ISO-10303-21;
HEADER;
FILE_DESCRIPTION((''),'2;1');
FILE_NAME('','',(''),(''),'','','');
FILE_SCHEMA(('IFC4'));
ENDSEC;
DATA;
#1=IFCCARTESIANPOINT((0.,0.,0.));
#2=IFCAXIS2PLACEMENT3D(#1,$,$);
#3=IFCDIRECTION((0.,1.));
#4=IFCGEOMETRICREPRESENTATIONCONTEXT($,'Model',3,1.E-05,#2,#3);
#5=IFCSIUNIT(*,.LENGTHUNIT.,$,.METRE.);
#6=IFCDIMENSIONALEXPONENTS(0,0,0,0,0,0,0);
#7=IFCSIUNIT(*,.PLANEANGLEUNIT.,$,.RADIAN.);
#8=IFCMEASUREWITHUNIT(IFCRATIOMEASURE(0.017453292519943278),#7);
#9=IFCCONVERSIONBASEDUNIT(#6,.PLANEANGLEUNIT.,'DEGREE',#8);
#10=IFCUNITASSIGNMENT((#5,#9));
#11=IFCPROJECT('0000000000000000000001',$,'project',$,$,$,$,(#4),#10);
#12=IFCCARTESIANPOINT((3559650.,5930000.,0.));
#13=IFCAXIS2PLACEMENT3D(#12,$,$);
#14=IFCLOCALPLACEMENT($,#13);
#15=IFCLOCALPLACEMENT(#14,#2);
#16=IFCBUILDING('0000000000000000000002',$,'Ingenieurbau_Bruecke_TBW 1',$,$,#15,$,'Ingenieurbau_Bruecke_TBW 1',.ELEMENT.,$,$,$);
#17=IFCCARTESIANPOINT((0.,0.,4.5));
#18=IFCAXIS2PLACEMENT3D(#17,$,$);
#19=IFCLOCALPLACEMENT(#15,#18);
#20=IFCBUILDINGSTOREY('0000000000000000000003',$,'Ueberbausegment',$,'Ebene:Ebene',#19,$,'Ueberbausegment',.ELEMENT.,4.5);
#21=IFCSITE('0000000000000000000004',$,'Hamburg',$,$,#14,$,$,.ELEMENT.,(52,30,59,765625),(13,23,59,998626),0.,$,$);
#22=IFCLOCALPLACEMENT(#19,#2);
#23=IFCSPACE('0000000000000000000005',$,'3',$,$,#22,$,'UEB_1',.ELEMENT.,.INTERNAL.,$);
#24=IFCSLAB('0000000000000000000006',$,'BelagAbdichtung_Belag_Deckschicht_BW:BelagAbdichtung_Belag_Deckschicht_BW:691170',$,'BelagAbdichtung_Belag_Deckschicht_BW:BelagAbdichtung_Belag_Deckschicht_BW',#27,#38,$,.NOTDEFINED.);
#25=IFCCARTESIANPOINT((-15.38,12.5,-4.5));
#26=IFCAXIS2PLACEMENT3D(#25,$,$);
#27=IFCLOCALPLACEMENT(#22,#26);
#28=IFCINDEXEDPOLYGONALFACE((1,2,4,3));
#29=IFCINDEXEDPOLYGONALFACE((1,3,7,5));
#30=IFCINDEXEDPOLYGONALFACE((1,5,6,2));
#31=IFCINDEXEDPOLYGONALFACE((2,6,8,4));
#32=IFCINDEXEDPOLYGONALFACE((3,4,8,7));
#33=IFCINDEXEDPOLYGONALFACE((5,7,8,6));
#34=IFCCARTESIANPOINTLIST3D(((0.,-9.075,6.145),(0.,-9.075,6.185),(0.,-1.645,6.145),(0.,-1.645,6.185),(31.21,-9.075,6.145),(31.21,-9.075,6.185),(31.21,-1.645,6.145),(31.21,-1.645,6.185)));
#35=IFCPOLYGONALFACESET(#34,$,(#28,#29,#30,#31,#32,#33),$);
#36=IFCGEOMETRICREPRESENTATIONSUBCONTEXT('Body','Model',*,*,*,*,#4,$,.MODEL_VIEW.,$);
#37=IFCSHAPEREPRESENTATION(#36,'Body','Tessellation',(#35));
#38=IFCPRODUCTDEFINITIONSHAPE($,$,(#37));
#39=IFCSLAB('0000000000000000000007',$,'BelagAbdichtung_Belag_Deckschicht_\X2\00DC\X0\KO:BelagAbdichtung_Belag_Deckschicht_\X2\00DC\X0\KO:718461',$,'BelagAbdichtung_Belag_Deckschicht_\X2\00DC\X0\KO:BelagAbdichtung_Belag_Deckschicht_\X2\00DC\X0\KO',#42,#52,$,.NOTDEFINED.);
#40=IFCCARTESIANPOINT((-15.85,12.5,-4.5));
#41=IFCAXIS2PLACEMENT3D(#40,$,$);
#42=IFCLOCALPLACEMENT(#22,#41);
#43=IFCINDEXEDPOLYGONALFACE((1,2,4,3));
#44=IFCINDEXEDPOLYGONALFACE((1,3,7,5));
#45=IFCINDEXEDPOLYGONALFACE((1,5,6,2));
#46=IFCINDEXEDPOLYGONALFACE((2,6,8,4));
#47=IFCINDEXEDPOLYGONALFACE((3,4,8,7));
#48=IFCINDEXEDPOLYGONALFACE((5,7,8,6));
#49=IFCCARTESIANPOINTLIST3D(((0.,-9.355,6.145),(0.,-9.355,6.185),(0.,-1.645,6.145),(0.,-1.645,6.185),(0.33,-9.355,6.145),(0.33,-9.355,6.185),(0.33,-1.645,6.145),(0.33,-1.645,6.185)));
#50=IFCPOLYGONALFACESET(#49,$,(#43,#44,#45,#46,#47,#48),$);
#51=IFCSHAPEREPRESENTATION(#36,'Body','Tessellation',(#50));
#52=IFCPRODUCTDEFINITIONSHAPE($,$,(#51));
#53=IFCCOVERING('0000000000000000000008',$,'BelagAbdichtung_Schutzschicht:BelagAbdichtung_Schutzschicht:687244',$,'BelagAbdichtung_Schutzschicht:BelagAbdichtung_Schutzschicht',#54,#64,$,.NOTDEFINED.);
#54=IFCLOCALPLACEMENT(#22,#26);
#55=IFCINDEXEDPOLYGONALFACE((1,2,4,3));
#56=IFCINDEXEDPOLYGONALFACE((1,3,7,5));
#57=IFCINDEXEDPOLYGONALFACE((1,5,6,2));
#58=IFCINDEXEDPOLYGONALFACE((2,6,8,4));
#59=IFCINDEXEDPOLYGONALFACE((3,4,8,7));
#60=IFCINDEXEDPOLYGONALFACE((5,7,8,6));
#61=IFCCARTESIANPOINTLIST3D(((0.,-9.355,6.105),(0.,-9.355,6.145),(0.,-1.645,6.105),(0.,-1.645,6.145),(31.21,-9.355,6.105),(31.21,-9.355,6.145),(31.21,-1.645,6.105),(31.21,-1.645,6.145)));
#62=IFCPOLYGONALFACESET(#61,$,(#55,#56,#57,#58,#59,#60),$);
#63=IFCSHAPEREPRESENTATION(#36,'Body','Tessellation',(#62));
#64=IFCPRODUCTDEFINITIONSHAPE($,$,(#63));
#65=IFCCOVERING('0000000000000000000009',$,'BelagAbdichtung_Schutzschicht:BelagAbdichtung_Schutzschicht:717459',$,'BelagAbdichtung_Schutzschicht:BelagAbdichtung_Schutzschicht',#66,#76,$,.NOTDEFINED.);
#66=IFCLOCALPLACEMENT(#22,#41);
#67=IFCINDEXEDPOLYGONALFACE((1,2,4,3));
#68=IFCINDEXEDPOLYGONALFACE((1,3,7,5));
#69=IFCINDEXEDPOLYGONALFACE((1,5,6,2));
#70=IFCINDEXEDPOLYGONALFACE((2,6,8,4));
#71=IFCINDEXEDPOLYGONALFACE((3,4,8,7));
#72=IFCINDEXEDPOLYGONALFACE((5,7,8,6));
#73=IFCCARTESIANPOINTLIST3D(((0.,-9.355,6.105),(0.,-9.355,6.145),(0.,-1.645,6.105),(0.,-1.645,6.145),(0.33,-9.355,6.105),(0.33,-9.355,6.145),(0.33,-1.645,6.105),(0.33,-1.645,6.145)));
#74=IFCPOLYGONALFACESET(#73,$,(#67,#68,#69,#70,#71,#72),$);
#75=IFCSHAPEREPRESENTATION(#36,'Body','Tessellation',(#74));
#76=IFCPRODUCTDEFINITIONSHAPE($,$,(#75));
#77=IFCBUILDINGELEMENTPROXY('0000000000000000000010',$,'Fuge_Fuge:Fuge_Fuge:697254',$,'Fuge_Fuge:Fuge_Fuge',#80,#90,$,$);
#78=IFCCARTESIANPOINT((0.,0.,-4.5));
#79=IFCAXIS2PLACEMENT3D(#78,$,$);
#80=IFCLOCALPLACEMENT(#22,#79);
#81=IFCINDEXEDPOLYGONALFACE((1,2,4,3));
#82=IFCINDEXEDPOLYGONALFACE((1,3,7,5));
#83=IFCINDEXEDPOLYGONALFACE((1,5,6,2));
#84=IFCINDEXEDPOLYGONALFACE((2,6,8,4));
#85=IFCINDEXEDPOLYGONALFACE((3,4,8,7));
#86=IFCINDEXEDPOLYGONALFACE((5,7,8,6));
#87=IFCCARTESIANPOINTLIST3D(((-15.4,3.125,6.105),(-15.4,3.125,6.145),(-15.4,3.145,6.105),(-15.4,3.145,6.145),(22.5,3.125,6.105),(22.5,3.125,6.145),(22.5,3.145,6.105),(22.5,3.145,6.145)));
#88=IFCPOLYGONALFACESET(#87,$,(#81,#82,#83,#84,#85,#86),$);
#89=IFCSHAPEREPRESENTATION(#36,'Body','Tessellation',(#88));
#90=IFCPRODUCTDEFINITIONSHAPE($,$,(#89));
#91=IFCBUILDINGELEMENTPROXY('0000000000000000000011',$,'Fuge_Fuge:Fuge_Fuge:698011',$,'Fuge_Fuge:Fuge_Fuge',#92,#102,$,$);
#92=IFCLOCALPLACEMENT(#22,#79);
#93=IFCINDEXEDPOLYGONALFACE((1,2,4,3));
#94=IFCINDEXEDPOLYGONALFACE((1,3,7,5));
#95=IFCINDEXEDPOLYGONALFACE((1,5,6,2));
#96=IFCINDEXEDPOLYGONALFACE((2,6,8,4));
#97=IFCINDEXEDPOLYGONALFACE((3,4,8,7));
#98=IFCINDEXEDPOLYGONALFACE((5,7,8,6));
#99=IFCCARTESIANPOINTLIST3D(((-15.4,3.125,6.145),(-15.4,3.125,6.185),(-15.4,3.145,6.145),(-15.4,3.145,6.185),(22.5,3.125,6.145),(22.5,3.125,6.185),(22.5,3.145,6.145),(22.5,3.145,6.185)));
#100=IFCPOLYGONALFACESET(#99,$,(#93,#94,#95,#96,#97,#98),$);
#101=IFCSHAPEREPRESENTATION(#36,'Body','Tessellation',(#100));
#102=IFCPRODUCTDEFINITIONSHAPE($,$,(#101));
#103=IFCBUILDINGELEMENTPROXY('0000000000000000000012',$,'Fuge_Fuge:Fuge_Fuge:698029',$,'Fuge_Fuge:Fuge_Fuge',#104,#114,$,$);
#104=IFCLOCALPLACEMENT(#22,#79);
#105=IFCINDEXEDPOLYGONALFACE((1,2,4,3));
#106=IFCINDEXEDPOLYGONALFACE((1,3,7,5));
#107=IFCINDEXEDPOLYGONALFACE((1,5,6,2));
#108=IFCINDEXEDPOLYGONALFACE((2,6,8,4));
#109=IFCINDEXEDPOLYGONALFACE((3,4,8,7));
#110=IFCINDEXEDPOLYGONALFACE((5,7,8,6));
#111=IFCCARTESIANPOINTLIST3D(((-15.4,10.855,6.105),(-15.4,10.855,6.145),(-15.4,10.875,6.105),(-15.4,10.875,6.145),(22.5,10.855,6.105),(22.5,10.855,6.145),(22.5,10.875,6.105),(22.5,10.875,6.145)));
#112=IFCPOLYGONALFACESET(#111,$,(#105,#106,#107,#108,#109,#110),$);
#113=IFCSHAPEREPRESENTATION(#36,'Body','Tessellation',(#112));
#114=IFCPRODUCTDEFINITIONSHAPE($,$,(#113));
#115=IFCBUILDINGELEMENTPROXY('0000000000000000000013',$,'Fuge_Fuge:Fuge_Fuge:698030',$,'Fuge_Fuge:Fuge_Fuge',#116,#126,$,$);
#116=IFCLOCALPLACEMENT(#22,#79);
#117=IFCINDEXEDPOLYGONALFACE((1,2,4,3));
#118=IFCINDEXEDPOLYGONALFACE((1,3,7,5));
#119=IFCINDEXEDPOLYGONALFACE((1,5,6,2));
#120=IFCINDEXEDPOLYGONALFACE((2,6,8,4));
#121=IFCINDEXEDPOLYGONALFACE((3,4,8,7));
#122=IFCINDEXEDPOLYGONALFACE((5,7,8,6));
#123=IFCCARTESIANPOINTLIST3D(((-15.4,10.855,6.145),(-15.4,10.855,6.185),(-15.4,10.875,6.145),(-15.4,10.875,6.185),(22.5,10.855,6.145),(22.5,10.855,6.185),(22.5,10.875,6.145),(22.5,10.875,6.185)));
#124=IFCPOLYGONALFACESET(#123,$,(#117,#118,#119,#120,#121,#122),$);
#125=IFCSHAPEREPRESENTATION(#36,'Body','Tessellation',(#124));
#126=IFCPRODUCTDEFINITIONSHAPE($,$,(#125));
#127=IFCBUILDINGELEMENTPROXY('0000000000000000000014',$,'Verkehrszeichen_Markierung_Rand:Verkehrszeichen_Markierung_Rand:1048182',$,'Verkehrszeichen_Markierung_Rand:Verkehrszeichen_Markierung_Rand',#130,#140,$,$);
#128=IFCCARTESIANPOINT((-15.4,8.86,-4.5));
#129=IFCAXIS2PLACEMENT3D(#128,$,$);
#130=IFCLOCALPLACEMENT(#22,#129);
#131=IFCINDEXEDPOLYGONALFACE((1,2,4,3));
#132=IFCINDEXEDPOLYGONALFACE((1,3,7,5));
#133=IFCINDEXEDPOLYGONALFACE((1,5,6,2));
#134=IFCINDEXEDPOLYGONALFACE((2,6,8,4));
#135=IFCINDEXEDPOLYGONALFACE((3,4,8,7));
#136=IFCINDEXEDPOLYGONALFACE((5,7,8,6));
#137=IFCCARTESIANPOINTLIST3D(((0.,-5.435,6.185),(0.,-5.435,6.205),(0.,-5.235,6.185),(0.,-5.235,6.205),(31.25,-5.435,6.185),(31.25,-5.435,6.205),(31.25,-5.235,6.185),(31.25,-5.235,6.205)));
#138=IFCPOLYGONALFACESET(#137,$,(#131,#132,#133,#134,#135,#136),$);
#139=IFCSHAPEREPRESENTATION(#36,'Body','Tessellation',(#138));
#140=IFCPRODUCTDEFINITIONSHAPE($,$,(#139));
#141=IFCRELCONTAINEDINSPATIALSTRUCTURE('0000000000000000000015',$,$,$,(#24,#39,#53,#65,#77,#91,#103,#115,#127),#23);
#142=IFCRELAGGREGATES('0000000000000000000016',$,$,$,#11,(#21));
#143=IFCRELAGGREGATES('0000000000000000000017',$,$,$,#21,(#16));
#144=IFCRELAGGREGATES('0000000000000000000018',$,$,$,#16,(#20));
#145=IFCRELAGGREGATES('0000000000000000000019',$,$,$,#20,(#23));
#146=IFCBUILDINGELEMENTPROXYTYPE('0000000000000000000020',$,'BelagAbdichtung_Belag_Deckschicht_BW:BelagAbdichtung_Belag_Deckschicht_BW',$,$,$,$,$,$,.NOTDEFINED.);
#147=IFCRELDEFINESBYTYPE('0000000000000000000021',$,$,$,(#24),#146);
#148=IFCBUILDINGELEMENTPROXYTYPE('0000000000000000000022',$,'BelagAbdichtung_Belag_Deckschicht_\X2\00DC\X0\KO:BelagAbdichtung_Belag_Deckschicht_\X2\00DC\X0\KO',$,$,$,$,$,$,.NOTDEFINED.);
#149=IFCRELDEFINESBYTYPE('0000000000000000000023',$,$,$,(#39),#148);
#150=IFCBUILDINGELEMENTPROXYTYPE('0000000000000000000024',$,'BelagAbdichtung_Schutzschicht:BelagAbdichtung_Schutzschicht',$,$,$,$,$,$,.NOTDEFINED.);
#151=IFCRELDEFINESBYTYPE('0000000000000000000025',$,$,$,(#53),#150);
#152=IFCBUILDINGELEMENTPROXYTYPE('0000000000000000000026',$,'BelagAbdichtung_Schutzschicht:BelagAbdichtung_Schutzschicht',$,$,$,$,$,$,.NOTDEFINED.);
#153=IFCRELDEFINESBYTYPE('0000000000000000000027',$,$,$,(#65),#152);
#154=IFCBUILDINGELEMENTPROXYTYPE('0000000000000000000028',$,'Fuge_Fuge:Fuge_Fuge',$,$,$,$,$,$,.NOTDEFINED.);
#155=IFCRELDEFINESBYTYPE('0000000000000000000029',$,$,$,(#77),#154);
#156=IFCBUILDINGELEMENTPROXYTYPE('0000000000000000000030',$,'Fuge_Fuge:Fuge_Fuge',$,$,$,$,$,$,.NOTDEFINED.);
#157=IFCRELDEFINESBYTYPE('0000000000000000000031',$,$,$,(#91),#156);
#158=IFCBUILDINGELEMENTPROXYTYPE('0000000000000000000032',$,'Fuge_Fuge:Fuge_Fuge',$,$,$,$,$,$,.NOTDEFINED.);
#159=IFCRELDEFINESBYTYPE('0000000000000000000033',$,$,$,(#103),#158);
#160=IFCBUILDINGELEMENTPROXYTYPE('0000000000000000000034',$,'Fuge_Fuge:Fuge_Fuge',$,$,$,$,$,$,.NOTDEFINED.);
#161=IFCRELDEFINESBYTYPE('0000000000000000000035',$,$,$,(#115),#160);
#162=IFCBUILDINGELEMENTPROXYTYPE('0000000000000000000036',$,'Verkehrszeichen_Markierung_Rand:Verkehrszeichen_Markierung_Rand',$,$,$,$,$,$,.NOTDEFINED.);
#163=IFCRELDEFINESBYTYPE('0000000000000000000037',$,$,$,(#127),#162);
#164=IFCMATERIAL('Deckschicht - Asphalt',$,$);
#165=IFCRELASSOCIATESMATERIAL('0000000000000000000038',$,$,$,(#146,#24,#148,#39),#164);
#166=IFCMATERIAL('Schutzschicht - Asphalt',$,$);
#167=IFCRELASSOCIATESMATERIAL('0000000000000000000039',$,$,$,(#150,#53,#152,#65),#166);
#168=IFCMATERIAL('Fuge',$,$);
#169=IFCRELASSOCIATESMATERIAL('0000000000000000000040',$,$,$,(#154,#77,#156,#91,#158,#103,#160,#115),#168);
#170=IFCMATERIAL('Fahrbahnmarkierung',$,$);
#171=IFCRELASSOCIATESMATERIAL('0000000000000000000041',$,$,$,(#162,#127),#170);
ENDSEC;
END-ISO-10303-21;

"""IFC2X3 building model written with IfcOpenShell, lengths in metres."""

from ifc_helpers import new_model, entity, si_unit, converted_unit, direction, frame, origin, origin_2d_with_axis, place, context, subcontext, project, spatial, rectangle, extrude, source, transform, mapped, material, type_object, type_shapes, element, save


model = new_model("IFC2X3")

# Units and contexts
model_context = context("Model", 3, precision=1e-05, world=origin(), true_north=direction((0.0, 1.0)))
body_context = subcontext(model_context, "Body", "Model", "MODEL_VIEW")
ifc_project = project(units=[si_unit("LENGTHUNIT", "METRE"), converted_unit("PLANEANGLEUNIT", "DEGREE", entity("IfcRatioMeasure", 0.017453292519943278), si_unit("PLANEANGLEUNIT", "RADIAN"), dimensions=[0, 0, 0, 0, 0, 0, 0])], contexts=[model_context])

# Site, building, storey, space
site_placement = place(None, frame((3559650.0, 5930000.0, 0.0)))
site = spatial("IfcSite", under=ifc_project, at=site_placement, Name="Hamburg", CompositionType="ELEMENT", RefLatitude=(52, 30, 59, 765625), RefLongitude=(13, 23, 59, 998626), RefElevation=0.0)
building_placement = place(site_placement, origin())
building = spatial("IfcBuilding", under=site, at=building_placement, Name="Ingenieurbau_Bruecke_TBW 1", LongName="Ingenieurbau_Bruecke_TBW 1", CompositionType="ELEMENT")
storey_placement = place(building_placement, frame((0.0, 0.0, 4.5)))
storey = spatial("IfcBuildingStorey", under=building, at=storey_placement, Name="Ueberbausegment", ObjectType="Ebene:Ebene", LongName="Ueberbausegment", CompositionType="ELEMENT", Elevation=4.5)
space_placement = place(storey_placement, origin())
space = spatial("IfcSpace", under=storey, at=space_placement, Name="3", LongName="UEB_1", CompositionType="ELEMENT", InteriorOrExteriorSpace="INTERNAL")

# Slabs
ifc_material_1 = material(Name="Deckschicht - Asphalt")
building_element_proxy_type_1 = type_object("IfcBuildingElementProxyType", Name="BelagAbdichtung_Belag_Deckschicht_BW:BelagAbdichtung_Belag_Deckschicht_BW", PredefinedType="NOTDEFINED", material=ifc_material_1)
shared_shape_1 = source(origin(), body_context, "Body", "SweptSolid", [
    extrude(rectangle(XDim=31.21, YDim=7.43, at=origin_2d_with_axis()), frame((15.605, -5.36, 6.145), z_axis=(0.0, 0.0, 1.0), x_axis=(-1.0, 0.0, 0.0)), (0.0, 0.0, 1.0), 0.04),
])
type_shapes(building_element_proxy_type_1, [shared_shape_1])
slab_1_placement = place(space_placement, frame((-15.38, 12.5, -4.5)))
element("IfcSlab", 1, at=slab_1_placement, inside=space, type_object=building_element_proxy_type_1, material=ifc_material_1, Name="BelagAbdichtung_Belag_Deckschicht_BW:BelagAbdichtung_Belag_Deckschicht_BW:691170", ObjectType="BelagAbdichtung_Belag_Deckschicht_BW:BelagAbdichtung_Belag_Deckschicht_BW", PredefinedType="NOTDEFINED", context=body_context, shape_type="MappedRepresentation", body=[
    mapped(shared_shape_1, transform((0.0, 0.0, 0.0), scale=1.0)),
])
building_element_proxy_type_2 = type_object("IfcBuildingElementProxyType", Name="BelagAbdichtung_Belag_Deckschicht_ÜKO:BelagAbdichtung_Belag_Deckschicht_ÜKO", PredefinedType="NOTDEFINED", material=ifc_material_1)
shared_shape_2 = source(origin(), body_context, "Body", "SweptSolid", [
    extrude(rectangle(XDim=0.33, YDim=7.71, at=origin_2d_with_axis()), frame((0.165, -5.5, 6.145), z_axis=(0.0, 0.0, 1.0), x_axis=(-1.0, 0.0, 0.0)), (0.0, 0.0, 1.0), 0.04),
])
type_shapes(building_element_proxy_type_2, [shared_shape_2])
slab_2_placement = place(space_placement, frame((-15.85, 12.5, -4.5)))
element("IfcSlab", 2, at=slab_2_placement, inside=space, type_object=building_element_proxy_type_2, material=ifc_material_1, Name="BelagAbdichtung_Belag_Deckschicht_ÜKO:BelagAbdichtung_Belag_Deckschicht_ÜKO:718461", ObjectType="BelagAbdichtung_Belag_Deckschicht_ÜKO:BelagAbdichtung_Belag_Deckschicht_ÜKO", PredefinedType="NOTDEFINED", context=body_context, shape_type="MappedRepresentation", body=[
    mapped(shared_shape_2, transform((0.0, 0.0, 0.0), scale=1.0)),
])

# Coverings
ifc_material_2 = material(Name="Schutzschicht - Asphalt")
building_element_proxy_type_3 = type_object("IfcBuildingElementProxyType", Name="BelagAbdichtung_Schutzschicht:BelagAbdichtung_Schutzschicht", PredefinedType="NOTDEFINED", material=ifc_material_2)
shared_shape_3 = source(origin(), body_context, "Body", "SweptSolid", [
    extrude(rectangle(XDim=31.21, YDim=7.71, at=origin_2d_with_axis()), frame((15.605, -5.5, 6.105), z_axis=(0.0, 0.0, 1.0), x_axis=(-1.0, 0.0, 0.0)), (0.0, 0.0, 1.0), 0.04),
])
type_shapes(building_element_proxy_type_3, [shared_shape_3])
covering_1_placement = place(space_placement, frame((-15.38, 12.5, -4.5)))
element("IfcCovering", 3, at=covering_1_placement, inside=space, type_object=building_element_proxy_type_3, material=ifc_material_2, Name="BelagAbdichtung_Schutzschicht:BelagAbdichtung_Schutzschicht:687244", ObjectType="BelagAbdichtung_Schutzschicht:BelagAbdichtung_Schutzschicht", PredefinedType="NOTDEFINED", context=body_context, shape_type="MappedRepresentation", body=[
    mapped(shared_shape_3, transform((0.0, 0.0, 0.0), scale=1.0)),
])
building_element_proxy_type_4 = type_object("IfcBuildingElementProxyType", Name="BelagAbdichtung_Schutzschicht:BelagAbdichtung_Schutzschicht", PredefinedType="NOTDEFINED", material=ifc_material_2)
shared_shape_4 = source(origin(), body_context, "Body", "SweptSolid", [
    extrude(rectangle(XDim=0.33, YDim=7.71, at=origin_2d_with_axis()), frame((0.165, -5.5, 6.105), z_axis=(0.0, 0.0, 1.0), x_axis=(-1.0, 0.0, 0.0)), (0.0, 0.0, 1.0), 0.04),
])
type_shapes(building_element_proxy_type_4, [shared_shape_4])
covering_2_placement = place(space_placement, frame((-15.85, 12.5, -4.5)))
element("IfcCovering", 4, at=covering_2_placement, inside=space, type_object=building_element_proxy_type_4, material=ifc_material_2, Name="BelagAbdichtung_Schutzschicht:BelagAbdichtung_Schutzschicht:717459", ObjectType="BelagAbdichtung_Schutzschicht:BelagAbdichtung_Schutzschicht", PredefinedType="NOTDEFINED", context=body_context, shape_type="MappedRepresentation", body=[
    mapped(shared_shape_4, transform((0.0, 0.0, 0.0), scale=1.0)),
])

# Building element proxies
ifc_material_3 = material(Name="Fuge")
building_element_proxy_type_5 = type_object("IfcBuildingElementProxyType", Name="Fuge_Fuge:Fuge_Fuge", PredefinedType="NOTDEFINED", material=ifc_material_3)
shared_shape_5 = source(origin(), body_context, "Body", "SweptSolid", [
    extrude(rectangle(XDim=37.9, YDim=0.02, at=origin_2d_with_axis()), frame((3.55, 3.135, 6.105), z_axis=(0.0, 0.0, 1.0), x_axis=(-1.0, 0.0, 0.0)), (0.0, 0.0, 1.0), 0.04),
])
type_shapes(building_element_proxy_type_5, [shared_shape_5])
proxy_1_placement = place(space_placement, frame((0.0, 0.0, -4.5)))
element("IfcBuildingElementProxy", 5, at=proxy_1_placement, inside=space, type_object=building_element_proxy_type_5, material=ifc_material_3, Name="Fuge_Fuge:Fuge_Fuge:697254", ObjectType="Fuge_Fuge:Fuge_Fuge", context=body_context, shape_type="MappedRepresentation", body=[
    mapped(shared_shape_5, transform((0.0, 0.0, 0.0), scale=1.0)),
])
building_element_proxy_type_6 = type_object("IfcBuildingElementProxyType", Name="Fuge_Fuge:Fuge_Fuge", PredefinedType="NOTDEFINED", material=ifc_material_3)
shared_shape_6 = source(origin(), body_context, "Body", "SweptSolid", [
    extrude(rectangle(XDim=37.9, YDim=0.02, at=origin_2d_with_axis()), frame((3.55, 3.135, 6.145), z_axis=(0.0, 0.0, 1.0), x_axis=(-1.0, 0.0, 0.0)), (0.0, 0.0, 1.0), 0.04),
])
type_shapes(building_element_proxy_type_6, [shared_shape_6])
proxy_2_placement = place(space_placement, frame((0.0, 0.0, -4.5)))
element("IfcBuildingElementProxy", 6, at=proxy_2_placement, inside=space, type_object=building_element_proxy_type_6, material=ifc_material_3, Name="Fuge_Fuge:Fuge_Fuge:698011", ObjectType="Fuge_Fuge:Fuge_Fuge", context=body_context, shape_type="MappedRepresentation", body=[
    mapped(shared_shape_6, transform((0.0, 0.0, 0.0), scale=1.0)),
])
building_element_proxy_type_7 = type_object("IfcBuildingElementProxyType", Name="Fuge_Fuge:Fuge_Fuge", PredefinedType="NOTDEFINED", material=ifc_material_3)
shared_shape_7 = source(origin(), body_context, "Body", "SweptSolid", [
    extrude(rectangle(XDim=37.9, YDim=0.02, at=origin_2d_with_axis()), frame((3.55, 10.865, 6.105), z_axis=(0.0, 0.0, 1.0), x_axis=(-1.0, 0.0, 0.0)), (0.0, 0.0, 1.0), 0.04),
])
type_shapes(building_element_proxy_type_7, [shared_shape_7])
proxy_3_placement = place(space_placement, frame((0.0, 0.0, -4.5)))
element("IfcBuildingElementProxy", 7, at=proxy_3_placement, inside=space, type_object=building_element_proxy_type_7, material=ifc_material_3, Name="Fuge_Fuge:Fuge_Fuge:698029", ObjectType="Fuge_Fuge:Fuge_Fuge", context=body_context, shape_type="MappedRepresentation", body=[
    mapped(shared_shape_7, transform((0.0, 0.0, 0.0), scale=1.0)),
])
building_element_proxy_type_8 = type_object("IfcBuildingElementProxyType", Name="Fuge_Fuge:Fuge_Fuge", PredefinedType="NOTDEFINED", material=ifc_material_3)
shared_shape_8 = source(origin(), body_context, "Body", "SweptSolid", [
    extrude(rectangle(XDim=37.9, YDim=0.02, at=origin_2d_with_axis()), frame((3.55, 10.865, 6.145), z_axis=(0.0, 0.0, 1.0), x_axis=(-1.0, 0.0, 0.0)), (0.0, 0.0, 1.0), 0.04),
])
type_shapes(building_element_proxy_type_8, [shared_shape_8])
proxy_4_placement = place(space_placement, frame((0.0, 0.0, -4.5)))
element("IfcBuildingElementProxy", 8, at=proxy_4_placement, inside=space, type_object=building_element_proxy_type_8, material=ifc_material_3, Name="Fuge_Fuge:Fuge_Fuge:698030", ObjectType="Fuge_Fuge:Fuge_Fuge", context=body_context, shape_type="MappedRepresentation", body=[
    mapped(shared_shape_8, transform((0.0, 0.0, 0.0), scale=1.0)),
])
ifc_material_4 = material(Name="Fahrbahnmarkierung")
building_element_proxy_type_9 = type_object("IfcBuildingElementProxyType", Name="Verkehrszeichen_Markierung_Rand:Verkehrszeichen_Markierung_Rand", PredefinedType="NOTDEFINED", material=ifc_material_4)
shared_shape_9 = source(origin(), body_context, "Body", "SweptSolid", [
    extrude(rectangle(XDim=31.25, YDim=0.2, at=origin_2d_with_axis()), frame((15.625, -5.335, 6.185), z_axis=(0.0, 0.0, 1.0), x_axis=(-1.0, 0.0, 0.0)), (0.0, 0.0, 1.0), 0.02),
])
type_shapes(building_element_proxy_type_9, [shared_shape_9])
proxy_5_placement = place(space_placement, frame((-15.4, 8.86, -4.5)))
element("IfcBuildingElementProxy", 9, at=proxy_5_placement, inside=space, type_object=building_element_proxy_type_9, material=ifc_material_4, Name="Verkehrszeichen_Markierung_Rand:Verkehrszeichen_Markierung_Rand:1048182", ObjectType="Verkehrszeichen_Markierung_Rand:Verkehrszeichen_Markierung_Rand", context=body_context, shape_type="MappedRepresentation", body=[
    mapped(shared_shape_9, transform((0.0, 0.0, 0.0), scale=1.0)),
])

save(model, "model.ifc")
